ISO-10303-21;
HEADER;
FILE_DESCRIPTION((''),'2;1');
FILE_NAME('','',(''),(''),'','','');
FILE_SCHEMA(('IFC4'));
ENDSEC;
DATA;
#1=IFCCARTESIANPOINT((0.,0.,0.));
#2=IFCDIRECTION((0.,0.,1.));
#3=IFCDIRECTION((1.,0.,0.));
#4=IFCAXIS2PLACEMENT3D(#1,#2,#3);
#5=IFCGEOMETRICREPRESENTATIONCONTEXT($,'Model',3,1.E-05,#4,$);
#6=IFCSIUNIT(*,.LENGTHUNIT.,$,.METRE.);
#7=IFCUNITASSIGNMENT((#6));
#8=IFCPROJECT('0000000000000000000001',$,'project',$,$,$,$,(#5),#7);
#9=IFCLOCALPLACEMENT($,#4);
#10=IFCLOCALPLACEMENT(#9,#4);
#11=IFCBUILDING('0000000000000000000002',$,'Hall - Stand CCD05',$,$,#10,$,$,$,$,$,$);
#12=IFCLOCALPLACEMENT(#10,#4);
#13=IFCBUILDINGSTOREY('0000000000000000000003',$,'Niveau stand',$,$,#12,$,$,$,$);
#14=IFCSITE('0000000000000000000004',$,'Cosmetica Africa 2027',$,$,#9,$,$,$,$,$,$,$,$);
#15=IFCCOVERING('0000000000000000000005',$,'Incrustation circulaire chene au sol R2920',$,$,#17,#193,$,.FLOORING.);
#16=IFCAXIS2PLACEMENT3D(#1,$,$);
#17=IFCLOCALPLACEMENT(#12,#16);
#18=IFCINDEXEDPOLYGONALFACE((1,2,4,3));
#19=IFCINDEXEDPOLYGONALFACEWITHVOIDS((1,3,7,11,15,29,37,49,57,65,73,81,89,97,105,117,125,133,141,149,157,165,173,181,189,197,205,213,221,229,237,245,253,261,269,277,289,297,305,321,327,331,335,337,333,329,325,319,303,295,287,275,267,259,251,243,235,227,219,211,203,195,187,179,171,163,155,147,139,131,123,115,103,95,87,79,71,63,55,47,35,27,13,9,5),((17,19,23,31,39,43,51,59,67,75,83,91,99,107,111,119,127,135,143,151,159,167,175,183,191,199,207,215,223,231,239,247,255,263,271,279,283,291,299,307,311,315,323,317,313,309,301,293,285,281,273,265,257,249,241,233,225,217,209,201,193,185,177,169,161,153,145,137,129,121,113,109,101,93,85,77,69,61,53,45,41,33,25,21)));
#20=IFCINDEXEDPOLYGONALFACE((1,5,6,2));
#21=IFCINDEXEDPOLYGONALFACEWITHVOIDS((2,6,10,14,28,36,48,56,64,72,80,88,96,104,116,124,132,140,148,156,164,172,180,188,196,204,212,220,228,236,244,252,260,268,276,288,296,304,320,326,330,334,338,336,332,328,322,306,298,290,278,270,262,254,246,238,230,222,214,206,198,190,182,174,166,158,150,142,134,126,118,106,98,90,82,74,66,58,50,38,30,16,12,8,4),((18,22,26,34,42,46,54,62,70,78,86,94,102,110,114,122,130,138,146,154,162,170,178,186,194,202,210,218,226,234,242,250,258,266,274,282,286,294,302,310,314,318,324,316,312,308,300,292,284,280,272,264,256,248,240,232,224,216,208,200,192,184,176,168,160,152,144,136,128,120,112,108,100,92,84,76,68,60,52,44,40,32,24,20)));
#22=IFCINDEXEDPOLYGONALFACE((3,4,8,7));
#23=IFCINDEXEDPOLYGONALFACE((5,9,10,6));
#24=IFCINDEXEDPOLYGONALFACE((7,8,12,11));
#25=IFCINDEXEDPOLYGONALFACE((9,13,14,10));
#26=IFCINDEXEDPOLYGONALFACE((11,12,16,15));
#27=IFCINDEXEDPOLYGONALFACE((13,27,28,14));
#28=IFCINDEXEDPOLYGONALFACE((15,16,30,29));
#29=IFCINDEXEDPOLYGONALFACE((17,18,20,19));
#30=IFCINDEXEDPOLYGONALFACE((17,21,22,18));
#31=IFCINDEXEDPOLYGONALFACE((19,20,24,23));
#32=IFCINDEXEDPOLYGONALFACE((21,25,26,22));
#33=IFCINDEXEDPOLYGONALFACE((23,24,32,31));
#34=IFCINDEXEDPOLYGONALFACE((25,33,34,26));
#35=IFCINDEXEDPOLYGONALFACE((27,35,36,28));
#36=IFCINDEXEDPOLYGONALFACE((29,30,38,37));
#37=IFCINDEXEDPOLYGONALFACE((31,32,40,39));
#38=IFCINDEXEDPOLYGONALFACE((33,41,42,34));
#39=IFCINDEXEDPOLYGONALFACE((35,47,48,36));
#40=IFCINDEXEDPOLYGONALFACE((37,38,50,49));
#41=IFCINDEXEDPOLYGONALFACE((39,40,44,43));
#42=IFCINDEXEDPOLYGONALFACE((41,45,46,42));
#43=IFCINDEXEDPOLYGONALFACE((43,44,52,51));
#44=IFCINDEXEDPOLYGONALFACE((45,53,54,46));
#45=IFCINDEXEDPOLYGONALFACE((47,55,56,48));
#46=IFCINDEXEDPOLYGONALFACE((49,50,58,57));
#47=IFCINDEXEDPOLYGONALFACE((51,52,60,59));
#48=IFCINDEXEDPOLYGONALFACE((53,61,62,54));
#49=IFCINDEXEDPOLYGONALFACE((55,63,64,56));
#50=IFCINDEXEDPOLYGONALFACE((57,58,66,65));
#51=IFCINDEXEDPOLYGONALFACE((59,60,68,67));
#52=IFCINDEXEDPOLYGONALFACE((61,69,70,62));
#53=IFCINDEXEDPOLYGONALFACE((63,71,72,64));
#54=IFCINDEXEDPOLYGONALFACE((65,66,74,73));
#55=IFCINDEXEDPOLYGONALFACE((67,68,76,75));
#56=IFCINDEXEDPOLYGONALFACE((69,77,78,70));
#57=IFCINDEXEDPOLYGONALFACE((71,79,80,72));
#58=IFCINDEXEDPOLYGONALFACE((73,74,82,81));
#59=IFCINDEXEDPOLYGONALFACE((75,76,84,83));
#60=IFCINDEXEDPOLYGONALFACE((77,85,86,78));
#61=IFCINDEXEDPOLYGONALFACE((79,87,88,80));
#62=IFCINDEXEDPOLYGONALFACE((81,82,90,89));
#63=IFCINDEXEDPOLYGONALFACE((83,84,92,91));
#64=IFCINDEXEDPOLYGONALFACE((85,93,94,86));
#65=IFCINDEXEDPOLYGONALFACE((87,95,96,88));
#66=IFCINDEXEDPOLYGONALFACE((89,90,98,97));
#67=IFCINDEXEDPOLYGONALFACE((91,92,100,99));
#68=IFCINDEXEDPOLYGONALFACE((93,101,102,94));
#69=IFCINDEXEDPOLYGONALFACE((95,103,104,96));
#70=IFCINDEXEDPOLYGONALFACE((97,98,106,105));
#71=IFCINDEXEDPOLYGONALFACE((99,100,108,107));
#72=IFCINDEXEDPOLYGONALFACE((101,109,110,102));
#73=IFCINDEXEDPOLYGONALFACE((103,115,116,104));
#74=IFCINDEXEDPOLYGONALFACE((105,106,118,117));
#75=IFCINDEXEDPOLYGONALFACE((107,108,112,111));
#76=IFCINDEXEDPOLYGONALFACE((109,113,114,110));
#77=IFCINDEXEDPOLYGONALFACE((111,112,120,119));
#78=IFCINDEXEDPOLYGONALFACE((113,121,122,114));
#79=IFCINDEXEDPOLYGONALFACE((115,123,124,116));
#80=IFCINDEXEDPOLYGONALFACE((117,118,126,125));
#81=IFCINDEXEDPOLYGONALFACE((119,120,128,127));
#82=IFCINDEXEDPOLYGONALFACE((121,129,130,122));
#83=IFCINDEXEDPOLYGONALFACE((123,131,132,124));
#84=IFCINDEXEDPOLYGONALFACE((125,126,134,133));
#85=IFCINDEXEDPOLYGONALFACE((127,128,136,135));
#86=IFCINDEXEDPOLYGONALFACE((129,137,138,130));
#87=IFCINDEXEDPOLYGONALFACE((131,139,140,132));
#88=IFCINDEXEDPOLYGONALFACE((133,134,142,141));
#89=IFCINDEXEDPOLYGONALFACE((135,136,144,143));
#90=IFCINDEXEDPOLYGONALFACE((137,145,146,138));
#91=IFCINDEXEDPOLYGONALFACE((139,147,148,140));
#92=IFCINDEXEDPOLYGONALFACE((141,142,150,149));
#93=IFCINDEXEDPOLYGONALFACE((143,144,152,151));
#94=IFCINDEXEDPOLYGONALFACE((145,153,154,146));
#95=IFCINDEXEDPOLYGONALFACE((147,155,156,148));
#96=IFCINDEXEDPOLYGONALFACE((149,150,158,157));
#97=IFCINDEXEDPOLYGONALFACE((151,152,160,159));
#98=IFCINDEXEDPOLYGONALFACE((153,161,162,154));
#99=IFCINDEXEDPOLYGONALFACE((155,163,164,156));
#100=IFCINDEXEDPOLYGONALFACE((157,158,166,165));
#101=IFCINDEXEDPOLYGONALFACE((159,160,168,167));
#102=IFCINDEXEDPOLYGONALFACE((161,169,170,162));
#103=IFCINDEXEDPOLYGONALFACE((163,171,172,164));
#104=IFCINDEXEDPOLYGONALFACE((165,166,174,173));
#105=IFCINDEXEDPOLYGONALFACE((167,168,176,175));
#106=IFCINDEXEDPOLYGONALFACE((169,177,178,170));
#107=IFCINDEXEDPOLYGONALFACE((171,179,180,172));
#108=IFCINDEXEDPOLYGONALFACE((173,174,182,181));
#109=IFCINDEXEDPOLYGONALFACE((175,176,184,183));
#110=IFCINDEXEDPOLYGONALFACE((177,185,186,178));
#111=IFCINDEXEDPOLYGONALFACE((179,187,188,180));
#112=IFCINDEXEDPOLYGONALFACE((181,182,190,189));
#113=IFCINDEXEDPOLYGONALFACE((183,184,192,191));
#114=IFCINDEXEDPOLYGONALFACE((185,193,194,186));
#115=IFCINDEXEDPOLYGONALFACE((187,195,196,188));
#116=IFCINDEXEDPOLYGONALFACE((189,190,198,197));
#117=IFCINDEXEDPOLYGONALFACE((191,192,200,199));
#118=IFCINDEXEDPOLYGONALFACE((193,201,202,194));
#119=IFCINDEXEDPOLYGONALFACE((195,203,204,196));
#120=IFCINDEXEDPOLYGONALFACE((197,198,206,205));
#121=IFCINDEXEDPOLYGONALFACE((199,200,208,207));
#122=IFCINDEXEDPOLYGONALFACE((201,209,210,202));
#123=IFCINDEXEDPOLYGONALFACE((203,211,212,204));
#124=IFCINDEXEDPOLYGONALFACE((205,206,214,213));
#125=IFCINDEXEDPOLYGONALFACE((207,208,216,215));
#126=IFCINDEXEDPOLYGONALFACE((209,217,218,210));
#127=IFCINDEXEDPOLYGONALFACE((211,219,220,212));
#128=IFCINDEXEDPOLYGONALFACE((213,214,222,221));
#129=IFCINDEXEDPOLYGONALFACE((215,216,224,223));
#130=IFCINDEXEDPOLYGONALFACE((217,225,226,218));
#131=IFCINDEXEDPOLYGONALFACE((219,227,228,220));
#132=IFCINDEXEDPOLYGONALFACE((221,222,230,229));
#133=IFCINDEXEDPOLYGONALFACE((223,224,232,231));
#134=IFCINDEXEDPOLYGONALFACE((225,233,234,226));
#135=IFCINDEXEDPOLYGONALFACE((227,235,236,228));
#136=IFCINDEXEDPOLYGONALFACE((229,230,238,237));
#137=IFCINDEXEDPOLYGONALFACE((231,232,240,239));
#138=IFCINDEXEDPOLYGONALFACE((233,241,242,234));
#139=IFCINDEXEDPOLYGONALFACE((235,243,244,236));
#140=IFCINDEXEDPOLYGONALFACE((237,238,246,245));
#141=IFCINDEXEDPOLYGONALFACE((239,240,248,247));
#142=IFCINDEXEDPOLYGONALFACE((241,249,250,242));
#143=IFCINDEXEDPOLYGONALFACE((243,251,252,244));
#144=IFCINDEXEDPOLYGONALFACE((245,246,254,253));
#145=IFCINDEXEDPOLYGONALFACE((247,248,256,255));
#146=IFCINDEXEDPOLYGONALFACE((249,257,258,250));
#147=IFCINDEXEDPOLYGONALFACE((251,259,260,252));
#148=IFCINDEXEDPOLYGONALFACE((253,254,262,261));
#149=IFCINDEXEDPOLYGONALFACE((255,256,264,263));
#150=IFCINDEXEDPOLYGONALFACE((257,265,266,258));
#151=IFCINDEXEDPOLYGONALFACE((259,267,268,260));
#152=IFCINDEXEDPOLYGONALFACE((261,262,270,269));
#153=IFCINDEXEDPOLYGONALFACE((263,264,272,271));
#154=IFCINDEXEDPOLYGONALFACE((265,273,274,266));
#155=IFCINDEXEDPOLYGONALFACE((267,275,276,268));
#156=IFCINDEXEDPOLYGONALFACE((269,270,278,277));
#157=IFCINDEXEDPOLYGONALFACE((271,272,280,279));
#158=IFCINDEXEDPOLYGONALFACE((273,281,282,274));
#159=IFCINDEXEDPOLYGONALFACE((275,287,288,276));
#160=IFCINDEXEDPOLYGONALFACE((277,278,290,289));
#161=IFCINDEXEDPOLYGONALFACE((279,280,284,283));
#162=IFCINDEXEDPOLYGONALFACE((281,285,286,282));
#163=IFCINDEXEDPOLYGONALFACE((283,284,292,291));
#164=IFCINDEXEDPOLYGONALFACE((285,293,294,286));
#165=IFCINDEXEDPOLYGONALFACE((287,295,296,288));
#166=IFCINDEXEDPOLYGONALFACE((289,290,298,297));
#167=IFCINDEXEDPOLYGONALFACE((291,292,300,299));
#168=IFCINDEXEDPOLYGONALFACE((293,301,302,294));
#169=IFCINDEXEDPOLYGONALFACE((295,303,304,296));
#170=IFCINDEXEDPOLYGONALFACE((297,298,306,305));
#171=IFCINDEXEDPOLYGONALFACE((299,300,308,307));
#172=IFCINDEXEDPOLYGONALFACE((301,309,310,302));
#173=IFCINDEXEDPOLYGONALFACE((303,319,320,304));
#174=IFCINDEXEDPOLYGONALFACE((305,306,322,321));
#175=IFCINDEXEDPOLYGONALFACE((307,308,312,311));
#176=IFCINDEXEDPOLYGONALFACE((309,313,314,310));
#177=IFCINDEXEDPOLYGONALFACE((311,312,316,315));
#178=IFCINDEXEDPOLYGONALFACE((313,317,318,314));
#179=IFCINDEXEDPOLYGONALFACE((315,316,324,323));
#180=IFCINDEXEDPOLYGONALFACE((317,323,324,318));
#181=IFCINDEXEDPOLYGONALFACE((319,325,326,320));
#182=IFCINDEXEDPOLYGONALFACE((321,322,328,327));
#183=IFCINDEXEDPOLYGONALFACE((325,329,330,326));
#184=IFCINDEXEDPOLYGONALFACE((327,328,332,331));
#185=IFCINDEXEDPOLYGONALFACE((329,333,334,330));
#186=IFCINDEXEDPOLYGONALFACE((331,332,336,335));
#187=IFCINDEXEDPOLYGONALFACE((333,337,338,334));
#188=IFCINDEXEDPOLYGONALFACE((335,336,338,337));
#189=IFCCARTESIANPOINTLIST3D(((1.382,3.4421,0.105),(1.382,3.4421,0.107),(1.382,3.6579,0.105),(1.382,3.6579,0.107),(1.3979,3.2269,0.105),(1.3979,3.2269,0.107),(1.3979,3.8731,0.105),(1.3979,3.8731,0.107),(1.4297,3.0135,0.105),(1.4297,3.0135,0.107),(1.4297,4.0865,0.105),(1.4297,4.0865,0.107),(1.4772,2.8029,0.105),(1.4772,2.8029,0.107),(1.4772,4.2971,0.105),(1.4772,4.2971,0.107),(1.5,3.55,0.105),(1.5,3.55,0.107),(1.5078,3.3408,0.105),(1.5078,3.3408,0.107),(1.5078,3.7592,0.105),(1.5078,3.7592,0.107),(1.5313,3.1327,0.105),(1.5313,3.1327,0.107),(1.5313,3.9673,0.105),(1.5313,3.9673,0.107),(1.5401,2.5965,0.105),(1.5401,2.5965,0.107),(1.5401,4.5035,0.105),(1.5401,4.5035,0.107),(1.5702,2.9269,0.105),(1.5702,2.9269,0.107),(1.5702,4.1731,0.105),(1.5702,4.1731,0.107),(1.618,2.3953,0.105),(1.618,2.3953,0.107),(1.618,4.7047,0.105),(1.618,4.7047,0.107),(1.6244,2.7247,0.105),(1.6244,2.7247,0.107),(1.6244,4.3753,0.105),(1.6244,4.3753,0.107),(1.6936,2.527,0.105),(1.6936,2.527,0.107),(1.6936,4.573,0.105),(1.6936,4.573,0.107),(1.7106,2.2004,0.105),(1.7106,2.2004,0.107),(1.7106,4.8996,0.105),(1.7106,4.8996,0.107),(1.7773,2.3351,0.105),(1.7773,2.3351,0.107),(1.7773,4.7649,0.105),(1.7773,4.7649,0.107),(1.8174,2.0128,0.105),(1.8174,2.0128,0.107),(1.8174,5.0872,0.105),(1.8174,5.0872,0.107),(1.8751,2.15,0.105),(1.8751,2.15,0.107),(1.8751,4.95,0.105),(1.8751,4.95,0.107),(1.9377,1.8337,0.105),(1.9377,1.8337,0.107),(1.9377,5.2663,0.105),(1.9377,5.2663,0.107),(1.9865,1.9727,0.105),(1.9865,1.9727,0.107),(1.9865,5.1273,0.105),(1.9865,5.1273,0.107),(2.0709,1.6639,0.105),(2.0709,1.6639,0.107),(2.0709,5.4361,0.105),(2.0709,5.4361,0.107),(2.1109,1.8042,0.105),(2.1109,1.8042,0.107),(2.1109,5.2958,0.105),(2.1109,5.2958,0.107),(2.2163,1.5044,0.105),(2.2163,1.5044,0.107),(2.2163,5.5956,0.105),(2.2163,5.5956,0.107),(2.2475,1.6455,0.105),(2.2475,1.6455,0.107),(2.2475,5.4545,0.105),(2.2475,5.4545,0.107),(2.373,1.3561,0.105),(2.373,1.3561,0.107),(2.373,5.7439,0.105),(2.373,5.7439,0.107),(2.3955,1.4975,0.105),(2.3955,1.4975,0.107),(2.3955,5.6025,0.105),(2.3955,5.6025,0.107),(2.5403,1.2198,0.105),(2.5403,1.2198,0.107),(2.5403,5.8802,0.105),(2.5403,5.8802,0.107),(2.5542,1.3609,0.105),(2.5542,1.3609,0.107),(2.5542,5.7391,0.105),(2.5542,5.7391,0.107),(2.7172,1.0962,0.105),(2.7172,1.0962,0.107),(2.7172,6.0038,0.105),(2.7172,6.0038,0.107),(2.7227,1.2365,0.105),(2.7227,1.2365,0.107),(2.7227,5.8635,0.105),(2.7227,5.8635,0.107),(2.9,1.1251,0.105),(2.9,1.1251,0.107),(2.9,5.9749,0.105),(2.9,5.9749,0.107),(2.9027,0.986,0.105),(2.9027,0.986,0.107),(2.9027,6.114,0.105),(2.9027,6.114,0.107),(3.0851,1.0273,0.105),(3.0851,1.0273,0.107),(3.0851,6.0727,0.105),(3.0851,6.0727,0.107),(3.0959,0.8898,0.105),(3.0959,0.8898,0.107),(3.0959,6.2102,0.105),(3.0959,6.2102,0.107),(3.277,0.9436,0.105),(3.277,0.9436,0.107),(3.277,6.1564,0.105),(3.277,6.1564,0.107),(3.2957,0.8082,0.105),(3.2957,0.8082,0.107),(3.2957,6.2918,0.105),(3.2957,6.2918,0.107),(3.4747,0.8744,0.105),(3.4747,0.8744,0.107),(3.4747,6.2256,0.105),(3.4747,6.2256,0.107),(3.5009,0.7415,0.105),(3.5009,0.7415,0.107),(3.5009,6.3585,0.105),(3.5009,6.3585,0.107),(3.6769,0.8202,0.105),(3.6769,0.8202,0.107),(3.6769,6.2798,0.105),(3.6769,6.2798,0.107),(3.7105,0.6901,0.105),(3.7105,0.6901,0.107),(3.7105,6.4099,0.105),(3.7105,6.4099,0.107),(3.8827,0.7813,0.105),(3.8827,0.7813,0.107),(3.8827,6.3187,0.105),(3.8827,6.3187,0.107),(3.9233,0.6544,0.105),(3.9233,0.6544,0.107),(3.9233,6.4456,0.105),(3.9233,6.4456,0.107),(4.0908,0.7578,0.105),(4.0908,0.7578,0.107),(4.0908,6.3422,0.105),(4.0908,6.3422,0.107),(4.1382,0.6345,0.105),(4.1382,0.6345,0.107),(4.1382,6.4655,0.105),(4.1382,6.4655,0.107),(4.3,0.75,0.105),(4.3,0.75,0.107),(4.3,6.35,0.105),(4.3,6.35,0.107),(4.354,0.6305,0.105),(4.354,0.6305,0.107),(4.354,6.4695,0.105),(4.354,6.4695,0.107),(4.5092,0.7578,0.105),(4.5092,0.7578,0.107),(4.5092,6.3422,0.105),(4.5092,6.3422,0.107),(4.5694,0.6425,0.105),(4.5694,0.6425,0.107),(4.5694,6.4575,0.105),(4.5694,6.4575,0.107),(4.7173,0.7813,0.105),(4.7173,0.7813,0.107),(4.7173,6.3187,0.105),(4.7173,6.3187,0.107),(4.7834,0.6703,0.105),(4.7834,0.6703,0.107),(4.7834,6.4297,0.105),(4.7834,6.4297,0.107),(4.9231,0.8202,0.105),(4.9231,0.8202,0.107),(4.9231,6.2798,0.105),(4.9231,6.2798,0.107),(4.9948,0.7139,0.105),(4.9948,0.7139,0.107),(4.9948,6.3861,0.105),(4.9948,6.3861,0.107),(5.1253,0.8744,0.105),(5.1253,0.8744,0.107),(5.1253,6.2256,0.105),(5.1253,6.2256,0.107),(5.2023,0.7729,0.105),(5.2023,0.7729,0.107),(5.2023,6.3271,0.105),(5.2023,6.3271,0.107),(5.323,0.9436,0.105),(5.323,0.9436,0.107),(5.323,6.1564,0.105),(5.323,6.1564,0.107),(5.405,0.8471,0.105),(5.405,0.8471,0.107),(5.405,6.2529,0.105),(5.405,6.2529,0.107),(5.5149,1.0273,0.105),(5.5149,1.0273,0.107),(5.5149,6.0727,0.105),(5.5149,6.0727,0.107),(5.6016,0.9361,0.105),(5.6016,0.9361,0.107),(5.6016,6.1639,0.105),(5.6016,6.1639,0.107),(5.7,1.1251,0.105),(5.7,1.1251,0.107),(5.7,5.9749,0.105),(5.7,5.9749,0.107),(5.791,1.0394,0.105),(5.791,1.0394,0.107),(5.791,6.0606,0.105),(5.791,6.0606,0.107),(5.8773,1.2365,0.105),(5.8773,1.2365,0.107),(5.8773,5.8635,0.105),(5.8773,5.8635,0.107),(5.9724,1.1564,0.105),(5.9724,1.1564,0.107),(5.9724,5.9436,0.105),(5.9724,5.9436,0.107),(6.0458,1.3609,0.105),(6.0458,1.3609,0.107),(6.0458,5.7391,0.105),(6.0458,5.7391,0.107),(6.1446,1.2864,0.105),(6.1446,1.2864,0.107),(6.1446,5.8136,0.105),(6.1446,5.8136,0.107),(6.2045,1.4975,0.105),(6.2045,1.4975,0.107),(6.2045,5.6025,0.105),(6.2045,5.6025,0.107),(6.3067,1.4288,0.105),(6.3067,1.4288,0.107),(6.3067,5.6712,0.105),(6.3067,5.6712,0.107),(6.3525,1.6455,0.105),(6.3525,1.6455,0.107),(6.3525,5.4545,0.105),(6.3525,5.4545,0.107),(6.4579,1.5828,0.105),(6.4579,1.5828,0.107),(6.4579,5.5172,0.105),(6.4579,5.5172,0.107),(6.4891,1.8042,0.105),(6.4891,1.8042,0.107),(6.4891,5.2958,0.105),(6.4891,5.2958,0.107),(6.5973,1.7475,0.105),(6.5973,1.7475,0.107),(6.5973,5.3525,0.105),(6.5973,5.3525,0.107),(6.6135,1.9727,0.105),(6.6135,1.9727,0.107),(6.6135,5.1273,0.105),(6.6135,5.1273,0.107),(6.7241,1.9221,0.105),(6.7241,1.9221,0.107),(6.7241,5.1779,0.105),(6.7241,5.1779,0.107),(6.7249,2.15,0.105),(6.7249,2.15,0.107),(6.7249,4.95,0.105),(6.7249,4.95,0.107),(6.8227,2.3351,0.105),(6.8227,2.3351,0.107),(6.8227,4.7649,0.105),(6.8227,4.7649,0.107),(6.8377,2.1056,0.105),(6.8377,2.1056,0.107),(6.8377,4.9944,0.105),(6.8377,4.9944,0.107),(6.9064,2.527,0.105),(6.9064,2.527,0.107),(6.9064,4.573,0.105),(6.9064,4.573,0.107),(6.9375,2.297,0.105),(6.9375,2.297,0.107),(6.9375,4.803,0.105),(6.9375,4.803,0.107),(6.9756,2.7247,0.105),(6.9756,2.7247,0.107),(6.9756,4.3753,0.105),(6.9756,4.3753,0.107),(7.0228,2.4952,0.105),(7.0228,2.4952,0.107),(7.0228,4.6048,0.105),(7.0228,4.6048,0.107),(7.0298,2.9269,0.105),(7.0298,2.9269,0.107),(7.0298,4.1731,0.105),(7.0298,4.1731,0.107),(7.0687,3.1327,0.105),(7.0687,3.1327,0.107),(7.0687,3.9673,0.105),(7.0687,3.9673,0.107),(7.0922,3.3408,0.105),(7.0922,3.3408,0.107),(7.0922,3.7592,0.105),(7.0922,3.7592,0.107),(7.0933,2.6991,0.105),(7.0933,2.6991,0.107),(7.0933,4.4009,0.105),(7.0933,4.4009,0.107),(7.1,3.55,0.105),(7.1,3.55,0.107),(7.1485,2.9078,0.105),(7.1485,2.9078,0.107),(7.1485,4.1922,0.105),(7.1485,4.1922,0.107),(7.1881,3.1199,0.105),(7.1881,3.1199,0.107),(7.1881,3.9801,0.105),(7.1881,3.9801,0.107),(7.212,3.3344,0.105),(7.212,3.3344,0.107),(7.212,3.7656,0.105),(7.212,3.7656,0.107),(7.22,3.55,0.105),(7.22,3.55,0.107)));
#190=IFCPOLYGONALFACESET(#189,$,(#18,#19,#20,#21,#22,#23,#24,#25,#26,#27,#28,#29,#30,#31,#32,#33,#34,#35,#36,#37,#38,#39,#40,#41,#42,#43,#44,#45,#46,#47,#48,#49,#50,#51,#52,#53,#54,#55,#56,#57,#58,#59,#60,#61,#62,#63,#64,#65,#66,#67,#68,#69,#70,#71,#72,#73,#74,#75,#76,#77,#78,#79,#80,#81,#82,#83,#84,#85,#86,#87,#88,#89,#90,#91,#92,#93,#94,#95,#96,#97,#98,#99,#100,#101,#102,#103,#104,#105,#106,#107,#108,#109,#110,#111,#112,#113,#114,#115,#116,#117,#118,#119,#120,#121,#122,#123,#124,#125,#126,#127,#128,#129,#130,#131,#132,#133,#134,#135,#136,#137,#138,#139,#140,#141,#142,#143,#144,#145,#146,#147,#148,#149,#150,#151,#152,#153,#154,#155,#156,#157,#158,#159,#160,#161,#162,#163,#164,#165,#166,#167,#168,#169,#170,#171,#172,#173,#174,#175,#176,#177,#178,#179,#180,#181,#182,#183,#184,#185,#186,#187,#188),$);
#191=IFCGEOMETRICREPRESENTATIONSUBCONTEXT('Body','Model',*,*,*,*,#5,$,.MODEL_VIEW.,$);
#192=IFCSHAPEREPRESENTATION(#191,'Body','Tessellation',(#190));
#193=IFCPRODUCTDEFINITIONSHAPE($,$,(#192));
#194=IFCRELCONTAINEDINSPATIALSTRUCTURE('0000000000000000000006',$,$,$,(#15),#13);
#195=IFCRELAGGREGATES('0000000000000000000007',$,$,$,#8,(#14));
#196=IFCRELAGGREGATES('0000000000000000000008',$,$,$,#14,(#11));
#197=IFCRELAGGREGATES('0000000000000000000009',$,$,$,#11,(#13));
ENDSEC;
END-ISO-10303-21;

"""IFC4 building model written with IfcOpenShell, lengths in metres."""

from ifc_helpers import new_model, si_unit, frame, frame_2d, origin_with_axes, place, context, subcontext, project, spatial, hollow_circle, extrude, element, save


model = new_model("IFC4")

# Units and contexts
model_context = context("Model", 3, precision=1e-05, world=origin_with_axes())
body_context = subcontext(model_context, "Body", "Model", "MODEL_VIEW")
ifc_project = project(units=[si_unit("LENGTHUNIT", "METRE")], contexts=[model_context])

# Site, building, storey
site_placement = place(None, origin_with_axes())
site = spatial("IfcSite", under=ifc_project, at=site_placement, Name="Cosmetica Africa 2027")
building_placement = place(site_placement, origin_with_axes())
building = spatial("IfcBuilding", under=site, at=building_placement, Name="Hall - Stand CCD05")
storey_placement = place(building_placement, origin_with_axes())
storey = spatial("IfcBuildingStorey", under=building, at=storey_placement, Name="Niveau stand")

# Covering
covering_1_placement = place(storey_placement, origin_with_axes())
element("IfcCovering", 1, at=covering_1_placement, inside=storey, Name="Incrustation circulaire chene au sol R2920", PredefinedType="FLOORING", context=body_context, shape_type="SweptSolid", body=[
    extrude(hollow_circle(Radius=2.92, WallThickness=0.12, at=frame_2d((4.3, 3.55))), frame((0.0, 0.0, 0.105)), (0.0, 0.0, 1.0), 0.002),
])

save(model, "model.ifc")
